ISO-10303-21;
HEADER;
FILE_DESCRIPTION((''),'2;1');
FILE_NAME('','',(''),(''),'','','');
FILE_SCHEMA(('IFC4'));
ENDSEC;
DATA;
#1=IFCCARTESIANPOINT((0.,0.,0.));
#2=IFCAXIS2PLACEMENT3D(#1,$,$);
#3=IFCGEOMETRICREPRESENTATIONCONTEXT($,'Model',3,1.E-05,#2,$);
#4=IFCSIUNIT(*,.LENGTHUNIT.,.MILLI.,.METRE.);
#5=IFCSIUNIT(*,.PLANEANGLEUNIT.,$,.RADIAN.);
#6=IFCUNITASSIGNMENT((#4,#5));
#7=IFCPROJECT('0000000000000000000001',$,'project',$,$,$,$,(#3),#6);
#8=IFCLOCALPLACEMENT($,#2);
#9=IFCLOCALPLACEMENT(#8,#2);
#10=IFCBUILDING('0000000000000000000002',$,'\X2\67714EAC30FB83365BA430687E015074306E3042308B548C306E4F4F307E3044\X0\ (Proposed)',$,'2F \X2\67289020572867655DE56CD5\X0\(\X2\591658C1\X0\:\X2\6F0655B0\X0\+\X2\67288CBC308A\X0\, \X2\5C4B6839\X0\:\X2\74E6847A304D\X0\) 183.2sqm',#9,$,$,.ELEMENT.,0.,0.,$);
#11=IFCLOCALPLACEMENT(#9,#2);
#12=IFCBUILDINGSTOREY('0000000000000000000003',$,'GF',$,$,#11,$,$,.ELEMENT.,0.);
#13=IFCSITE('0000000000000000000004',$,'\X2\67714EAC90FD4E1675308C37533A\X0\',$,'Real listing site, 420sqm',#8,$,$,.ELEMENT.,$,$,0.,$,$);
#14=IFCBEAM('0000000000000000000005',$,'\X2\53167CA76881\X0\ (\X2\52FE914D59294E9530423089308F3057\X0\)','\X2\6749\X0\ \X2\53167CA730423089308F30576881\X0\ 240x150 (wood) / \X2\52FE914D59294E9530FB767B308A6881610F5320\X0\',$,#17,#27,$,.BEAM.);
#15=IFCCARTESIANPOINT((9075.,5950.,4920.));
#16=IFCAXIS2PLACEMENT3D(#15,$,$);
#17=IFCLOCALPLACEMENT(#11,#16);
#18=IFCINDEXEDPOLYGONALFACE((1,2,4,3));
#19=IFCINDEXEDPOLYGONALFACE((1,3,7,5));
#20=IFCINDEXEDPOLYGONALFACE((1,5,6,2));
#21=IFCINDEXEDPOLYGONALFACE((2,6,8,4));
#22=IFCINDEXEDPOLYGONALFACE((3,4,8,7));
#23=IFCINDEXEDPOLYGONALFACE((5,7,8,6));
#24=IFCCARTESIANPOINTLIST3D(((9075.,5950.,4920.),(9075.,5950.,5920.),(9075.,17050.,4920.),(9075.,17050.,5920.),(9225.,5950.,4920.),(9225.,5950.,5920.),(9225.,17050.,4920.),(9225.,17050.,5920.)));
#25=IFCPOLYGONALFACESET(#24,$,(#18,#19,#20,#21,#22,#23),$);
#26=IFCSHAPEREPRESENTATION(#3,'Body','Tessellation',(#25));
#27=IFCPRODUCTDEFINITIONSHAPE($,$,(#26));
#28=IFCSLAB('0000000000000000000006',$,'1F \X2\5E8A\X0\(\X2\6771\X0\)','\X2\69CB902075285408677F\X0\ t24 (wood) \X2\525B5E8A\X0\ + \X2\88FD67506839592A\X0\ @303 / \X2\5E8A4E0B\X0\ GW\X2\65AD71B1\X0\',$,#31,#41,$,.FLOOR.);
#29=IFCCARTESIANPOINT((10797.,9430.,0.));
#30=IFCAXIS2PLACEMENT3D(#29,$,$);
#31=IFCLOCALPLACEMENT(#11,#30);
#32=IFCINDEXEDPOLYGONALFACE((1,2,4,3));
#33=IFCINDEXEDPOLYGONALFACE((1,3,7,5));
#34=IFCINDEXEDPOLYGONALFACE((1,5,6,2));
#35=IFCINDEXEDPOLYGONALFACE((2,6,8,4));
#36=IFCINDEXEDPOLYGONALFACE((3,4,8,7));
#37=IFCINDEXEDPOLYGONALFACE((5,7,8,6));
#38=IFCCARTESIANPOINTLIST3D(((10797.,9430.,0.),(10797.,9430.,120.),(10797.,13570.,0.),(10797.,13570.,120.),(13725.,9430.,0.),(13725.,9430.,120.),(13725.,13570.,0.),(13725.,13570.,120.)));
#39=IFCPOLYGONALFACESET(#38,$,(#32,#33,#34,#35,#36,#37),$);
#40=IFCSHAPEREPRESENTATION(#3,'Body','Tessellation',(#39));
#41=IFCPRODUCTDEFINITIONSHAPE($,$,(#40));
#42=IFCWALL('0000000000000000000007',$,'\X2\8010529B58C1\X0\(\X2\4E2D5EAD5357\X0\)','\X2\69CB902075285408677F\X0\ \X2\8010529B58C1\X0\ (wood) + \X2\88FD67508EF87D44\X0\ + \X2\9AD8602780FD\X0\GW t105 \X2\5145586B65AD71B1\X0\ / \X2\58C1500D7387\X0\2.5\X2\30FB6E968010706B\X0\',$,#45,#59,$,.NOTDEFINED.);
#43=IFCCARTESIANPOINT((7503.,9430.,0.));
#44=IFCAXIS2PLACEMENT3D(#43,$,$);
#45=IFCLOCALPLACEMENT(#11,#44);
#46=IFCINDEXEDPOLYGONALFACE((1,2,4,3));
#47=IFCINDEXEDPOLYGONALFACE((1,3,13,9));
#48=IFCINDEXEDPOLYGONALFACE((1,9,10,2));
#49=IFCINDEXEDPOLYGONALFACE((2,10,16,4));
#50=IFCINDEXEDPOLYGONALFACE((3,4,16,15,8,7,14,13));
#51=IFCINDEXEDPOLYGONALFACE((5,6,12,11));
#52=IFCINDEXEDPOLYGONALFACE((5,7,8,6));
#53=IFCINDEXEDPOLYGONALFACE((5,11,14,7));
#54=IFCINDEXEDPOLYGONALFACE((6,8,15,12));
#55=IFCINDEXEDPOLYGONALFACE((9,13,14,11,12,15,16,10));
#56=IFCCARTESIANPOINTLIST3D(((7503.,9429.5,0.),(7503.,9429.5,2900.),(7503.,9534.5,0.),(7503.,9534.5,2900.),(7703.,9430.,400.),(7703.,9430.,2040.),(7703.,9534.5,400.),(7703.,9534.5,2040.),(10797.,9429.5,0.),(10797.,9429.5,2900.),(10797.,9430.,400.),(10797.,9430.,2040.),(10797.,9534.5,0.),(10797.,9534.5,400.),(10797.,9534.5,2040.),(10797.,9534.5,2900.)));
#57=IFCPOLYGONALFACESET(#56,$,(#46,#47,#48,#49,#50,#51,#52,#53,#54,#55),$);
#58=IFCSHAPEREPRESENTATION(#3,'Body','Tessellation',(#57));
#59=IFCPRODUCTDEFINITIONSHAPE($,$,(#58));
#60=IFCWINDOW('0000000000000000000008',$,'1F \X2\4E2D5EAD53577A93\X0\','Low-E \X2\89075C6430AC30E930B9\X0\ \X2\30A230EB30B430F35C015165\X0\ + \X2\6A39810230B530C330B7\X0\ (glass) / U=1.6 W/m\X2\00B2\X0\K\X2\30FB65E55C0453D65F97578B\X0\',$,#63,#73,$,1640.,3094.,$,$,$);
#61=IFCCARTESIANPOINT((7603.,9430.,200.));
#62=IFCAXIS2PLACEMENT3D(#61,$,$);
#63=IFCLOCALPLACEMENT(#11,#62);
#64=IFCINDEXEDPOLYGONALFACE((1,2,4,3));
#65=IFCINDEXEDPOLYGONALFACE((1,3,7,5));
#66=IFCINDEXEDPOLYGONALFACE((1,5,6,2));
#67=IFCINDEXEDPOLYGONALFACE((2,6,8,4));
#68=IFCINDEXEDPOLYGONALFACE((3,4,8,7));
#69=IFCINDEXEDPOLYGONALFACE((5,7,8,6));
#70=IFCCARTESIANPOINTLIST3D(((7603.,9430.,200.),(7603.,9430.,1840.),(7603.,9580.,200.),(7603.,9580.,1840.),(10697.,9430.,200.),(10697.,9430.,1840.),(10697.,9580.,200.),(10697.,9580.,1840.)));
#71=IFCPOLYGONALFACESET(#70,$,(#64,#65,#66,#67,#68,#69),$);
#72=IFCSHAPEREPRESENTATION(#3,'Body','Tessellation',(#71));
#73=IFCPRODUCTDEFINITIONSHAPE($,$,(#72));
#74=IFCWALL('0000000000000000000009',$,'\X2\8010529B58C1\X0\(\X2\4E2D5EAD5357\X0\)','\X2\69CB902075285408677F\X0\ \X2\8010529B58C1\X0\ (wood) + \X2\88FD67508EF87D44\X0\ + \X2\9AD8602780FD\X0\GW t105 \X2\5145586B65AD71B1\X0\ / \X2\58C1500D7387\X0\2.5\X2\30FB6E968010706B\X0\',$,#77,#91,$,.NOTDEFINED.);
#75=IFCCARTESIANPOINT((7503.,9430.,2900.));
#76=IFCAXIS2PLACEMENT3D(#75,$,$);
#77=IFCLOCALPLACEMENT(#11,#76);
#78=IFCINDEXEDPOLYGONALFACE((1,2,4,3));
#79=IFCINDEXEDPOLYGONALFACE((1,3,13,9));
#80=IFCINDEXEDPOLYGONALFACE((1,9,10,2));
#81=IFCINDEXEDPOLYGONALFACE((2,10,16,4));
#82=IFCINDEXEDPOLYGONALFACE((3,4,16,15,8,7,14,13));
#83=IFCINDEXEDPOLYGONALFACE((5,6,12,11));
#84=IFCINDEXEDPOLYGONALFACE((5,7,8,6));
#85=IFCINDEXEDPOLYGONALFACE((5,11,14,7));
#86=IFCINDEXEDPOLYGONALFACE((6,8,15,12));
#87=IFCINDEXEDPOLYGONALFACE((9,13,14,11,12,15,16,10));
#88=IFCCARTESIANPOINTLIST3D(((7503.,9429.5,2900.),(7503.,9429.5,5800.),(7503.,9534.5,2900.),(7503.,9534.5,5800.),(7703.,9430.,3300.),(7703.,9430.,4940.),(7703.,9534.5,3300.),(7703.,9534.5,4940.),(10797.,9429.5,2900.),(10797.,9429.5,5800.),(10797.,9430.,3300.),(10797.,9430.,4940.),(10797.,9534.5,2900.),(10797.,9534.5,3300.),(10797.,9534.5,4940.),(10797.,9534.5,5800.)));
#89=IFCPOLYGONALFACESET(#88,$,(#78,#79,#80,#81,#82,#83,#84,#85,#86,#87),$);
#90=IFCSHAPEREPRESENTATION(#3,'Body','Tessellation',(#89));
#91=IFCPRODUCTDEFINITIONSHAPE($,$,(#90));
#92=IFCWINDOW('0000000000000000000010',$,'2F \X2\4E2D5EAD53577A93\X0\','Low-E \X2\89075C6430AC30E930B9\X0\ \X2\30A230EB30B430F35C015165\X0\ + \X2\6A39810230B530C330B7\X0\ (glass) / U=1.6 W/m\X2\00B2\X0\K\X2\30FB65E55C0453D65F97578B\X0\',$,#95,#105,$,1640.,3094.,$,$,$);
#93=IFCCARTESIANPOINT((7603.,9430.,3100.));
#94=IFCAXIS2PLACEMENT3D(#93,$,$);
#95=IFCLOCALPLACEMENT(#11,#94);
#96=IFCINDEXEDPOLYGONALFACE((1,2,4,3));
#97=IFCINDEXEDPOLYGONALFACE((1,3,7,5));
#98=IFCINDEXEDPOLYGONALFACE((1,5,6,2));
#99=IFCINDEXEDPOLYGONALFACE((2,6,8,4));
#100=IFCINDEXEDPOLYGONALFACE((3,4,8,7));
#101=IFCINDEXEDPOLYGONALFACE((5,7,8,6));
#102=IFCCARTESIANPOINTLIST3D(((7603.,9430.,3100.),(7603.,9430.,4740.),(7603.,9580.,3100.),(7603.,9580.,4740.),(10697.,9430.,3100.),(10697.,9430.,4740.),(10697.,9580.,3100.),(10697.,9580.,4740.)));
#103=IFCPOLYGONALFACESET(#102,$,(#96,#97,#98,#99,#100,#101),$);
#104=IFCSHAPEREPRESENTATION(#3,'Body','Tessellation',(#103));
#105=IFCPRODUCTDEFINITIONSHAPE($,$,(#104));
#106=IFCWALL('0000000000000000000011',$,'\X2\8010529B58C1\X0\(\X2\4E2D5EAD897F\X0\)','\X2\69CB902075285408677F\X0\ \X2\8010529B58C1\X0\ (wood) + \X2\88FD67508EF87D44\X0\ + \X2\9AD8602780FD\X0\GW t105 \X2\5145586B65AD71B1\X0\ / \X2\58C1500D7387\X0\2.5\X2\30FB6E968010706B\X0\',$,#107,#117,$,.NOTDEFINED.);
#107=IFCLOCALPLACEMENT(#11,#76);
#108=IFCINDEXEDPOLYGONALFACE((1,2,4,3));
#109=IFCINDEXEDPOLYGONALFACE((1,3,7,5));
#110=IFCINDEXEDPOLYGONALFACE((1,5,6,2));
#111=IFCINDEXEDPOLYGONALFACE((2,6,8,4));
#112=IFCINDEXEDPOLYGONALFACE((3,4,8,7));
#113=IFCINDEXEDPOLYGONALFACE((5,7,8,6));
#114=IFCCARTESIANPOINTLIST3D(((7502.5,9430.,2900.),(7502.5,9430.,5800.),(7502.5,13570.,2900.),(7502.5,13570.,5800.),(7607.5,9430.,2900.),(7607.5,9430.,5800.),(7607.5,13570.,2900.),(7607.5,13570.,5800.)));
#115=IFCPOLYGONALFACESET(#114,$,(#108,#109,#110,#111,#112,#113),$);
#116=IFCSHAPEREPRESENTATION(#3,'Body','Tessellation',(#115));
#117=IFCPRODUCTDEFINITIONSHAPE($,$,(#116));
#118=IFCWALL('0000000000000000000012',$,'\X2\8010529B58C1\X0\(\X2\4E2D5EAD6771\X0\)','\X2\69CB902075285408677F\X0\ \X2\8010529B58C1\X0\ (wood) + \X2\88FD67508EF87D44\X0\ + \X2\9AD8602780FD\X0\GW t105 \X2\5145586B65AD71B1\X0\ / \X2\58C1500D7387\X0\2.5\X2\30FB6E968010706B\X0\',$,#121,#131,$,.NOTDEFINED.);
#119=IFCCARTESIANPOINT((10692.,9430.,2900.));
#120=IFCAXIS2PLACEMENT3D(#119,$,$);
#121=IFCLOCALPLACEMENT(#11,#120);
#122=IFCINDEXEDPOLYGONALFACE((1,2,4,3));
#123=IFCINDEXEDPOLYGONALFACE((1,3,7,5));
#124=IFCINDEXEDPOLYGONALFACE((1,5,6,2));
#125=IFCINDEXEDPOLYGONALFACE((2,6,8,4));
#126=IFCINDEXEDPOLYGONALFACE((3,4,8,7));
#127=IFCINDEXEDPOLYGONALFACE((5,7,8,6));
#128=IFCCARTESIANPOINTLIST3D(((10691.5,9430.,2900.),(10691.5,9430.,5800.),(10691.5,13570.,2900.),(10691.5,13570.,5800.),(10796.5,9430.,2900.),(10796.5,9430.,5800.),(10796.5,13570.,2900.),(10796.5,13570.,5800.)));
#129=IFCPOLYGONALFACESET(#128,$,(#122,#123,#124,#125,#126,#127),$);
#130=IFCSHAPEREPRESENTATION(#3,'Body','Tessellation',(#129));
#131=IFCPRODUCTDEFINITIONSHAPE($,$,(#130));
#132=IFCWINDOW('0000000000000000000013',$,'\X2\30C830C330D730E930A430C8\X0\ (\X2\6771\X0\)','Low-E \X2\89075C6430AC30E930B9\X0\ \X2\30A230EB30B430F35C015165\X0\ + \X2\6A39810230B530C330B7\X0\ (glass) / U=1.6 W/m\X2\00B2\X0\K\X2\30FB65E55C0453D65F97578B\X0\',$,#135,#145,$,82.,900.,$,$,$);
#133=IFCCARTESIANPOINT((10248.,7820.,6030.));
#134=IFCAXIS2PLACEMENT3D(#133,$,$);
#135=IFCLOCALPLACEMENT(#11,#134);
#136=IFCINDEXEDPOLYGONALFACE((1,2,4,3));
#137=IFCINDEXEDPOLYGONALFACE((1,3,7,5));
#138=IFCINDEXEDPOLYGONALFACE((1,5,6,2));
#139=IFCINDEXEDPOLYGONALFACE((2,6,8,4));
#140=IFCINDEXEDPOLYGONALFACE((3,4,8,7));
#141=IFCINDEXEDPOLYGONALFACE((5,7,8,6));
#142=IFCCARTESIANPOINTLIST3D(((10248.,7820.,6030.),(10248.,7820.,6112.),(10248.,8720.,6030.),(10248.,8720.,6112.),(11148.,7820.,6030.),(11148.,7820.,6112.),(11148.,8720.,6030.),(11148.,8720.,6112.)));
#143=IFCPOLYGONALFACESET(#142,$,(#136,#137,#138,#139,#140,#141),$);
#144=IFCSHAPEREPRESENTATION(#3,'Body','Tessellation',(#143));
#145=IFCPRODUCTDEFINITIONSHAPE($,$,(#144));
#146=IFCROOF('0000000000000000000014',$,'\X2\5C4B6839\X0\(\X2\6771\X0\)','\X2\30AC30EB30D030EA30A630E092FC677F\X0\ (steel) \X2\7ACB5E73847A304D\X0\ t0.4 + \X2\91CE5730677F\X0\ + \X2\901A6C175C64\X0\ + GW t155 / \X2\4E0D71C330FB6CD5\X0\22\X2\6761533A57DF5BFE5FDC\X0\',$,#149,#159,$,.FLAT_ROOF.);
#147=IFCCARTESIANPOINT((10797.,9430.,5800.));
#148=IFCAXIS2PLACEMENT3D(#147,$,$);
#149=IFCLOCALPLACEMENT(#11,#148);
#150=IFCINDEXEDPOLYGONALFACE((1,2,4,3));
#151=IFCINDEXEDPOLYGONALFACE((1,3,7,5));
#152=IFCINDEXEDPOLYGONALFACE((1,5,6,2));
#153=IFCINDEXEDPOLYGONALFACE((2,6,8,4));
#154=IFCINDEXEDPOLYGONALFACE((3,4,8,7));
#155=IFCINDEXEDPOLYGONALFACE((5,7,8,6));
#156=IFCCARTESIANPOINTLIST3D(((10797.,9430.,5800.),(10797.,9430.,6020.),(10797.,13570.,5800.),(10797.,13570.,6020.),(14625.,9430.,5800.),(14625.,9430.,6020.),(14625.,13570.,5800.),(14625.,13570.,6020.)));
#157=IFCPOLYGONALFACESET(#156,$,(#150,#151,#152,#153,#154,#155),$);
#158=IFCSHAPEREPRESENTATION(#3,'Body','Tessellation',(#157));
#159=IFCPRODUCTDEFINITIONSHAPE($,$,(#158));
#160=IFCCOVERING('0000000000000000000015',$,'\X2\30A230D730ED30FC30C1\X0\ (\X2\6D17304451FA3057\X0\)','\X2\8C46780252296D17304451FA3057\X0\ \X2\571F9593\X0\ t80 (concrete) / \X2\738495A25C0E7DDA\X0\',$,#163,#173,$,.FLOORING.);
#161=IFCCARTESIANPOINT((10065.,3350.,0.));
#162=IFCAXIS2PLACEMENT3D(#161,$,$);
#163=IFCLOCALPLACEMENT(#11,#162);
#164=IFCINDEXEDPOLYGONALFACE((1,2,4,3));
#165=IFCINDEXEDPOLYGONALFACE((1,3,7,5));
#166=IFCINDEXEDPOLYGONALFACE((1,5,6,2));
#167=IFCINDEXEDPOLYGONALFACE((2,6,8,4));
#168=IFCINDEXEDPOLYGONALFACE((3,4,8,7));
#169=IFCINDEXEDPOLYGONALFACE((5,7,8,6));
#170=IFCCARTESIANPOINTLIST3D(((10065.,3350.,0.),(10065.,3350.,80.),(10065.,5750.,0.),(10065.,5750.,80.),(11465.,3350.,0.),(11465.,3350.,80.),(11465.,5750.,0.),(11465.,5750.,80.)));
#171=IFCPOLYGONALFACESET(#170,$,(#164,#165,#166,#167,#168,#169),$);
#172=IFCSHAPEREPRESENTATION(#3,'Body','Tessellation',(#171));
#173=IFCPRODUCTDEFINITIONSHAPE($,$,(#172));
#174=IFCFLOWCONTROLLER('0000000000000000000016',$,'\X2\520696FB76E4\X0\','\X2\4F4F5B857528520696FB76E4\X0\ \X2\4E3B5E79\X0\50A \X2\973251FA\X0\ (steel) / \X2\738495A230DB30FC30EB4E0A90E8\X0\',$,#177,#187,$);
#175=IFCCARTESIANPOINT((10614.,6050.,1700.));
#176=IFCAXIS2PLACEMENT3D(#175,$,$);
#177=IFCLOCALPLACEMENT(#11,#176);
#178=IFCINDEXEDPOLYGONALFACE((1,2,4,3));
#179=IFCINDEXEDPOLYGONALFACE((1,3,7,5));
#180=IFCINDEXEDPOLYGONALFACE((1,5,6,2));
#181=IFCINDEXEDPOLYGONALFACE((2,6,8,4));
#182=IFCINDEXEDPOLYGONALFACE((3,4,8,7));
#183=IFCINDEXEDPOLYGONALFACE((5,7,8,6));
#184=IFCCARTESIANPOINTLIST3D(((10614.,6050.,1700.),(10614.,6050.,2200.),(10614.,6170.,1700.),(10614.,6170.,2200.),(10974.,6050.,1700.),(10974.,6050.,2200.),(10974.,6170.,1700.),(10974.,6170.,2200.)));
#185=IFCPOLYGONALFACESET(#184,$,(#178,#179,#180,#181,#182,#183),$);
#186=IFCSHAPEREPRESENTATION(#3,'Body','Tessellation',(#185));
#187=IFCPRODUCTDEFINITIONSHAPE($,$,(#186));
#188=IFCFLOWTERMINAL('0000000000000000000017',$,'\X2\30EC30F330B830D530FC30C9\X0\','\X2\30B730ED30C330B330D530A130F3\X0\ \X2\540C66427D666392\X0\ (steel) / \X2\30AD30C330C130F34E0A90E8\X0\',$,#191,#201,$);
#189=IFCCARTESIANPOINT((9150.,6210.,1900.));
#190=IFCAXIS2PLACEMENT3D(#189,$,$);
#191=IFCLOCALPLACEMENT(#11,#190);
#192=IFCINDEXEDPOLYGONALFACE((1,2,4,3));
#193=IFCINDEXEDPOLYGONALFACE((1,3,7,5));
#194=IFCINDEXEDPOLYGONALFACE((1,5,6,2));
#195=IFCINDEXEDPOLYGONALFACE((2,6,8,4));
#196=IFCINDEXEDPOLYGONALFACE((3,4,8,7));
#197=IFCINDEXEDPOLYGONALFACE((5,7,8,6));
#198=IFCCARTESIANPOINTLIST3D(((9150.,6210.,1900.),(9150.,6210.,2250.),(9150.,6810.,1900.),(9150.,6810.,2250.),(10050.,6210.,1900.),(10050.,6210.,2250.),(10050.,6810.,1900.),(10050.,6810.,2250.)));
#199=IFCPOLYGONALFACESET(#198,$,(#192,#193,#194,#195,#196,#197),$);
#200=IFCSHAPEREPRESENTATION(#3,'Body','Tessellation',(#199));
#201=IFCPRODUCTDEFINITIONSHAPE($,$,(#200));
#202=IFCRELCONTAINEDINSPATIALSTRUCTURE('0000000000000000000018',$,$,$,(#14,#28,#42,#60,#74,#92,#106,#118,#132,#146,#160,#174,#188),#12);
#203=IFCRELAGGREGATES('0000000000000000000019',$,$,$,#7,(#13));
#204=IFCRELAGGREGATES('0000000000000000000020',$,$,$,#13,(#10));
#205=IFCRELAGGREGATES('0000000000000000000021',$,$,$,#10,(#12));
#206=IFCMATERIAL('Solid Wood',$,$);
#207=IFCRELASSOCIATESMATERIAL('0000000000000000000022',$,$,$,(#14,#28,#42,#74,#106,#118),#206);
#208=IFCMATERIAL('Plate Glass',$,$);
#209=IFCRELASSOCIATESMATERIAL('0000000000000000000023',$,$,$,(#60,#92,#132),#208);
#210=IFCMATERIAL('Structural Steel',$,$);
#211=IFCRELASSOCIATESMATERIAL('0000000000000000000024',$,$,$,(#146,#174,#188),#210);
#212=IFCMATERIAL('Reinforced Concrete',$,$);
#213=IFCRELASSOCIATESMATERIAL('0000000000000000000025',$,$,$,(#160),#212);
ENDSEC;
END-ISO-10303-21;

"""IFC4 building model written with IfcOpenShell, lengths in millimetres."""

from ifc_helpers import new_model, si_unit, frame, frame_2d, origin, place, context, project, spatial, rectangle, extrude, material, element, fill, save


model = new_model("IFC4")

# Units and contexts
model_context = context("Model", 3, precision=1e-05, world=origin())
ifc_project = project(units=[si_unit("LENGTHUNIT", "METRE", prefix="MILLI"), si_unit("PLANEANGLEUNIT", "RADIAN")], contexts=[model_context])

# Site, building, storey
site_placement = place(None, origin())
site = spatial("IfcSite", under=ifc_project, at=site_placement, Name="東京都世田谷区", ObjectType="Real listing site, 420sqm", CompositionType="ELEMENT", RefElevation=0.0)
building_placement = place(site_placement, origin())
building = spatial("IfcBuilding", under=site, at=building_placement, Name="東京・茶室と縁側のある和の住まい (Proposed)", ObjectType="2F 木造在来工法(外壁:漆喰+木貼り, 屋根:瓦葺き) 183.2sqm", CompositionType="ELEMENT", ElevationOfRefHeight=0.0, ElevationOfTerrain=0.0)
storey_placement = place(building_placement, origin())
storey = spatial("IfcBuildingStorey", under=building, at=storey_placement, Name="GF", CompositionType="ELEMENT", Elevation=0.0)

# Shared definitions
ifc_material_1 = material(Name="Solid Wood")

# Beam
beam_placement = place(storey_placement, frame((9075.0, 5950.0, 4920.0)))
element("IfcBeam", 1, at=beam_placement, inside=storey, material=ifc_material_1, Name="化粧梁 (勾配天井あらわし)", Description="杉 化粧あらわし梁 240x150 (wood) / 勾配天井・登り梁意匠", PredefinedType="BEAM", context=model_context, shape_type="SweptSolid", body=[
    extrude(rectangle(XDim=150.0, YDim=11100.0, at=frame_2d((75.0, 5550.0))), frame((9075.0, 5950.0, 4920.0)), (0.0, 0.0, 1.0), 1000.0),
])

# Slab
slab_placement = place(storey_placement, frame((10797.0, 9430.0, 0.0)))
element("IfcSlab", 2, at=slab_placement, inside=storey, material=ifc_material_1, Name="1F 床(東)", Description="構造用合板 t24 (wood) 剛床 + 製材根太 @303 / 床下 GW断熱", PredefinedType="FLOOR", context=model_context, shape_type="SweptSolid", body=[
    extrude(rectangle(XDim=2928.0, YDim=4140.0, at=frame_2d((1464.0, 2070.0))), frame((10797.0, 9430.0, 0.0)), (0.0, 0.0, 1.0), 120.0),
])

# Wall, opening, window
wall_1_placement = place(storey_placement, frame((7503.0, 9430.0, 0.0)))
wall_1 = element("IfcWall", 3, at=wall_1_placement, inside=storey, material=ifc_material_1, Name="耐力壁(中庭南)", Description="構造用合板 耐力壁 (wood) + 製材軸組 + 高性能GW t105 充填断熱 / 壁倍率2.5・準耐火", PredefinedType="NOTDEFINED", context=model_context, shape_type="SweptSolid", body=[
    extrude(rectangle(XDim=3294.0, YDim=105.0, at=frame_2d((1647.0, 52.0))), frame((7503.0, 9430.0, 0.0)), (0.0, 0.0, 1.0), 2900.0),
])
opening_1_placement = place(storey_placement, frame((7603.0, 9430.0, 200.0)))
opening_1 = element("IfcOpeningElement", 4, at=opening_1_placement, cuts=wall_1, PredefinedType="NOTDEFINED", context=model_context, shape_type="SweptSolid", body=[
    extrude(rectangle(XDim=3094.0, YDim=150.0, at=frame_2d((1547.0, 75.0))), frame((7603.0, 9430.0, 200.0)), (0.0, 0.0, 1.0), 1640.0),
])
ifc_material_2 = material(Name="Plate Glass")
window_1_placement = place(storey_placement, frame((7603.0, 9430.0, 200.0)))
window_1 = element("IfcWindow", 5, at=window_1_placement, inside=storey, material=ifc_material_2, Name="1F 中庭南窓", Description="Low-E 複層ガラス アルゴン封入 + 樹脂サッシ (glass) / U=1.6 W/m²K・日射取得型", OverallHeight=1640.0, OverallWidth=3094.0, context=model_context, shape_type="SweptSolid", body=[
    extrude(rectangle(XDim=3094.0, YDim=150.0, at=frame_2d((1547.0, 75.0))), frame((7603.0, 9430.0, 200.0)), (0.0, 0.0, 1.0), 1640.0),
])
fill(opening_1, window_1)

# Wall, opening, window
wall_2_placement = place(storey_placement, frame((7503.0, 9430.0, 2900.0)))
wall_2 = element("IfcWall", 6, at=wall_2_placement, inside=storey, material=ifc_material_1, Name="耐力壁(中庭南)", Description="構造用合板 耐力壁 (wood) + 製材軸組 + 高性能GW t105 充填断熱 / 壁倍率2.5・準耐火", PredefinedType="NOTDEFINED", context=model_context, shape_type="SweptSolid", body=[
    extrude(rectangle(XDim=3294.0, YDim=105.0, at=frame_2d((1647.0, 52.0))), frame((7503.0, 9430.0, 2900.0)), (0.0, 0.0, 1.0), 2900.0),
])
opening_2_placement = place(storey_placement, frame((7603.0, 9430.0, 3100.0)))
opening_2 = element("IfcOpeningElement", 7, at=opening_2_placement, cuts=wall_2, PredefinedType="NOTDEFINED", context=model_context, shape_type="SweptSolid", body=[
    extrude(rectangle(XDim=3094.0, YDim=150.0, at=frame_2d((1547.0, 75.0))), frame((7603.0, 9430.0, 3100.0)), (0.0, 0.0, 1.0), 1640.0),
])
window_2_placement = place(storey_placement, frame((7603.0, 9430.0, 3100.0)))
window_2 = element("IfcWindow", 8, at=window_2_placement, inside=storey, material=ifc_material_2, Name="2F 中庭南窓", Description="Low-E 複層ガラス アルゴン封入 + 樹脂サッシ (glass) / U=1.6 W/m²K・日射取得型", OverallHeight=1640.0, OverallWidth=3094.0, context=model_context, shape_type="SweptSolid", body=[
    extrude(rectangle(XDim=3094.0, YDim=150.0, at=frame_2d((1547.0, 75.0))), frame((7603.0, 9430.0, 3100.0)), (0.0, 0.0, 1.0), 1640.0),
])
fill(opening_2, window_2)

# Walls
wall_3_placement = place(storey_placement, frame((7503.0, 9430.0, 2900.0)))
element("IfcWall", 9, at=wall_3_placement, inside=storey, material=ifc_material_1, Name="耐力壁(中庭西)", Description="構造用合板 耐力壁 (wood) + 製材軸組 + 高性能GW t105 充填断熱 / 壁倍率2.5・準耐火", PredefinedType="NOTDEFINED", context=model_context, shape_type="SweptSolid", body=[
    extrude(rectangle(XDim=105.0, YDim=4140.0, at=frame_2d((52.0, 2070.0))), frame((7503.0, 9430.0, 2900.0)), (0.0, 0.0, 1.0), 2900.0),
])
wall_4_placement = place(storey_placement, frame((10692.0, 9430.0, 2900.0)))
element("IfcWall", 10, at=wall_4_placement, inside=storey, material=ifc_material_1, Name="耐力壁(中庭東)", Description="構造用合板 耐力壁 (wood) + 製材軸組 + 高性能GW t105 充填断熱 / 壁倍率2.5・準耐火", PredefinedType="NOTDEFINED", context=model_context, shape_type="SweptSolid", body=[
    extrude(rectangle(XDim=105.0, YDim=4140.0, at=frame_2d((52.0, 2070.0))), frame((10692.0, 9430.0, 2900.0)), (0.0, 0.0, 1.0), 2900.0),
])

# Window
window_3_placement = place(storey_placement, frame((10248.0, 7820.0, 6030.0)))
element("IfcWindow", 11, at=window_3_placement, inside=storey, material=ifc_material_2, Name="トップライト (東)", Description="Low-E 複層ガラス アルゴン封入 + 樹脂サッシ (glass) / U=1.6 W/m²K・日射取得型", OverallHeight=82.0, OverallWidth=900.0, context=model_context, shape_type="SweptSolid", body=[
    extrude(rectangle(XDim=900.0, YDim=900.0, at=frame_2d((450.0, 450.0))), frame((10248.0, 7820.0, 6030.0)), (0.0, 0.0, 1.0), 82.0),
])

# Roof
ifc_material_3 = material(Name="Structural Steel")
roof_placement = place(storey_placement, frame((10797.0, 9430.0, 5800.0)))
element("IfcRoof", 12, at=roof_placement, inside=storey, material=ifc_material_3, Name="屋根(東)", Description="ガルバリウム鋼板 (steel) 立平葺き t0.4 + 野地板 + 通気層 + GW t155 / 不燃・法22条区域対応", PredefinedType="FLAT_ROOF", context=model_context, shape_type="SweptSolid", body=[
    extrude(rectangle(XDim=3828.0, YDim=4140.0, at=frame_2d((1914.0, 2070.0))), frame((10797.0, 9430.0, 5800.0)), (0.0, 0.0, 1.0), 220.0),
])

# Covering
ifc_material_4 = material(Name="Reinforced Concrete")
covering_placement = place(storey_placement, frame((10065.0, 3350.0, 0.0)))
element("IfcCovering", 13, at=covering_placement, inside=storey, material=ifc_material_4, Name="アプローチ (洗い出し)", Description="豆砂利洗い出し 土間 t80 (concrete) / 玄関導線", PredefinedType="FLOORING", context=model_context, shape_type="SweptSolid", body=[
    extrude(rectangle(XDim=1400.0, YDim=2400.0, at=frame_2d((700.0, 1200.0))), frame((10065.0, 3350.0, 0.0)), (0.0, 0.0, 1.0), 80.0),
])

# Flow controller
flow_controller_placement = place(storey_placement, frame((10614.0, 6050.0, 1700.0)))
element("IfcFlowController", 14, at=flow_controller_placement, inside=storey, material=ifc_material_3, Name="分電盤", Description="住宅用分電盤 主幹50A 露出 (steel) / 玄関ホール上部", context=model_context, shape_type="SweptSolid", body=[
    extrude(rectangle(XDim=360.0, YDim=120.0, at=frame_2d((180.0, 60.0))), frame((10614.0, 6050.0, 1700.0)), (0.0, 0.0, 1.0), 500.0),
])

# Flow terminal
flow_terminal_1_placement = place(storey_placement, frame((9150.0, 6210.0, 1900.0)))
element("IfcFlowTerminal", 15, at=flow_terminal_1_placement, inside=storey, material=ifc_material_3, Name="レンジフード", Description="シロッコファン 同時給排 (steel) / キッチン上部", context=model_context, shape_type="SweptSolid", body=[
    extrude(rectangle(XDim=900.0, YDim=600.0, at=frame_2d((450.0, 300.0))), frame((9150.0, 6210.0, 1900.0)), (0.0, 0.0, 1.0), 350.0),
])

save(model, "model.ifc")
